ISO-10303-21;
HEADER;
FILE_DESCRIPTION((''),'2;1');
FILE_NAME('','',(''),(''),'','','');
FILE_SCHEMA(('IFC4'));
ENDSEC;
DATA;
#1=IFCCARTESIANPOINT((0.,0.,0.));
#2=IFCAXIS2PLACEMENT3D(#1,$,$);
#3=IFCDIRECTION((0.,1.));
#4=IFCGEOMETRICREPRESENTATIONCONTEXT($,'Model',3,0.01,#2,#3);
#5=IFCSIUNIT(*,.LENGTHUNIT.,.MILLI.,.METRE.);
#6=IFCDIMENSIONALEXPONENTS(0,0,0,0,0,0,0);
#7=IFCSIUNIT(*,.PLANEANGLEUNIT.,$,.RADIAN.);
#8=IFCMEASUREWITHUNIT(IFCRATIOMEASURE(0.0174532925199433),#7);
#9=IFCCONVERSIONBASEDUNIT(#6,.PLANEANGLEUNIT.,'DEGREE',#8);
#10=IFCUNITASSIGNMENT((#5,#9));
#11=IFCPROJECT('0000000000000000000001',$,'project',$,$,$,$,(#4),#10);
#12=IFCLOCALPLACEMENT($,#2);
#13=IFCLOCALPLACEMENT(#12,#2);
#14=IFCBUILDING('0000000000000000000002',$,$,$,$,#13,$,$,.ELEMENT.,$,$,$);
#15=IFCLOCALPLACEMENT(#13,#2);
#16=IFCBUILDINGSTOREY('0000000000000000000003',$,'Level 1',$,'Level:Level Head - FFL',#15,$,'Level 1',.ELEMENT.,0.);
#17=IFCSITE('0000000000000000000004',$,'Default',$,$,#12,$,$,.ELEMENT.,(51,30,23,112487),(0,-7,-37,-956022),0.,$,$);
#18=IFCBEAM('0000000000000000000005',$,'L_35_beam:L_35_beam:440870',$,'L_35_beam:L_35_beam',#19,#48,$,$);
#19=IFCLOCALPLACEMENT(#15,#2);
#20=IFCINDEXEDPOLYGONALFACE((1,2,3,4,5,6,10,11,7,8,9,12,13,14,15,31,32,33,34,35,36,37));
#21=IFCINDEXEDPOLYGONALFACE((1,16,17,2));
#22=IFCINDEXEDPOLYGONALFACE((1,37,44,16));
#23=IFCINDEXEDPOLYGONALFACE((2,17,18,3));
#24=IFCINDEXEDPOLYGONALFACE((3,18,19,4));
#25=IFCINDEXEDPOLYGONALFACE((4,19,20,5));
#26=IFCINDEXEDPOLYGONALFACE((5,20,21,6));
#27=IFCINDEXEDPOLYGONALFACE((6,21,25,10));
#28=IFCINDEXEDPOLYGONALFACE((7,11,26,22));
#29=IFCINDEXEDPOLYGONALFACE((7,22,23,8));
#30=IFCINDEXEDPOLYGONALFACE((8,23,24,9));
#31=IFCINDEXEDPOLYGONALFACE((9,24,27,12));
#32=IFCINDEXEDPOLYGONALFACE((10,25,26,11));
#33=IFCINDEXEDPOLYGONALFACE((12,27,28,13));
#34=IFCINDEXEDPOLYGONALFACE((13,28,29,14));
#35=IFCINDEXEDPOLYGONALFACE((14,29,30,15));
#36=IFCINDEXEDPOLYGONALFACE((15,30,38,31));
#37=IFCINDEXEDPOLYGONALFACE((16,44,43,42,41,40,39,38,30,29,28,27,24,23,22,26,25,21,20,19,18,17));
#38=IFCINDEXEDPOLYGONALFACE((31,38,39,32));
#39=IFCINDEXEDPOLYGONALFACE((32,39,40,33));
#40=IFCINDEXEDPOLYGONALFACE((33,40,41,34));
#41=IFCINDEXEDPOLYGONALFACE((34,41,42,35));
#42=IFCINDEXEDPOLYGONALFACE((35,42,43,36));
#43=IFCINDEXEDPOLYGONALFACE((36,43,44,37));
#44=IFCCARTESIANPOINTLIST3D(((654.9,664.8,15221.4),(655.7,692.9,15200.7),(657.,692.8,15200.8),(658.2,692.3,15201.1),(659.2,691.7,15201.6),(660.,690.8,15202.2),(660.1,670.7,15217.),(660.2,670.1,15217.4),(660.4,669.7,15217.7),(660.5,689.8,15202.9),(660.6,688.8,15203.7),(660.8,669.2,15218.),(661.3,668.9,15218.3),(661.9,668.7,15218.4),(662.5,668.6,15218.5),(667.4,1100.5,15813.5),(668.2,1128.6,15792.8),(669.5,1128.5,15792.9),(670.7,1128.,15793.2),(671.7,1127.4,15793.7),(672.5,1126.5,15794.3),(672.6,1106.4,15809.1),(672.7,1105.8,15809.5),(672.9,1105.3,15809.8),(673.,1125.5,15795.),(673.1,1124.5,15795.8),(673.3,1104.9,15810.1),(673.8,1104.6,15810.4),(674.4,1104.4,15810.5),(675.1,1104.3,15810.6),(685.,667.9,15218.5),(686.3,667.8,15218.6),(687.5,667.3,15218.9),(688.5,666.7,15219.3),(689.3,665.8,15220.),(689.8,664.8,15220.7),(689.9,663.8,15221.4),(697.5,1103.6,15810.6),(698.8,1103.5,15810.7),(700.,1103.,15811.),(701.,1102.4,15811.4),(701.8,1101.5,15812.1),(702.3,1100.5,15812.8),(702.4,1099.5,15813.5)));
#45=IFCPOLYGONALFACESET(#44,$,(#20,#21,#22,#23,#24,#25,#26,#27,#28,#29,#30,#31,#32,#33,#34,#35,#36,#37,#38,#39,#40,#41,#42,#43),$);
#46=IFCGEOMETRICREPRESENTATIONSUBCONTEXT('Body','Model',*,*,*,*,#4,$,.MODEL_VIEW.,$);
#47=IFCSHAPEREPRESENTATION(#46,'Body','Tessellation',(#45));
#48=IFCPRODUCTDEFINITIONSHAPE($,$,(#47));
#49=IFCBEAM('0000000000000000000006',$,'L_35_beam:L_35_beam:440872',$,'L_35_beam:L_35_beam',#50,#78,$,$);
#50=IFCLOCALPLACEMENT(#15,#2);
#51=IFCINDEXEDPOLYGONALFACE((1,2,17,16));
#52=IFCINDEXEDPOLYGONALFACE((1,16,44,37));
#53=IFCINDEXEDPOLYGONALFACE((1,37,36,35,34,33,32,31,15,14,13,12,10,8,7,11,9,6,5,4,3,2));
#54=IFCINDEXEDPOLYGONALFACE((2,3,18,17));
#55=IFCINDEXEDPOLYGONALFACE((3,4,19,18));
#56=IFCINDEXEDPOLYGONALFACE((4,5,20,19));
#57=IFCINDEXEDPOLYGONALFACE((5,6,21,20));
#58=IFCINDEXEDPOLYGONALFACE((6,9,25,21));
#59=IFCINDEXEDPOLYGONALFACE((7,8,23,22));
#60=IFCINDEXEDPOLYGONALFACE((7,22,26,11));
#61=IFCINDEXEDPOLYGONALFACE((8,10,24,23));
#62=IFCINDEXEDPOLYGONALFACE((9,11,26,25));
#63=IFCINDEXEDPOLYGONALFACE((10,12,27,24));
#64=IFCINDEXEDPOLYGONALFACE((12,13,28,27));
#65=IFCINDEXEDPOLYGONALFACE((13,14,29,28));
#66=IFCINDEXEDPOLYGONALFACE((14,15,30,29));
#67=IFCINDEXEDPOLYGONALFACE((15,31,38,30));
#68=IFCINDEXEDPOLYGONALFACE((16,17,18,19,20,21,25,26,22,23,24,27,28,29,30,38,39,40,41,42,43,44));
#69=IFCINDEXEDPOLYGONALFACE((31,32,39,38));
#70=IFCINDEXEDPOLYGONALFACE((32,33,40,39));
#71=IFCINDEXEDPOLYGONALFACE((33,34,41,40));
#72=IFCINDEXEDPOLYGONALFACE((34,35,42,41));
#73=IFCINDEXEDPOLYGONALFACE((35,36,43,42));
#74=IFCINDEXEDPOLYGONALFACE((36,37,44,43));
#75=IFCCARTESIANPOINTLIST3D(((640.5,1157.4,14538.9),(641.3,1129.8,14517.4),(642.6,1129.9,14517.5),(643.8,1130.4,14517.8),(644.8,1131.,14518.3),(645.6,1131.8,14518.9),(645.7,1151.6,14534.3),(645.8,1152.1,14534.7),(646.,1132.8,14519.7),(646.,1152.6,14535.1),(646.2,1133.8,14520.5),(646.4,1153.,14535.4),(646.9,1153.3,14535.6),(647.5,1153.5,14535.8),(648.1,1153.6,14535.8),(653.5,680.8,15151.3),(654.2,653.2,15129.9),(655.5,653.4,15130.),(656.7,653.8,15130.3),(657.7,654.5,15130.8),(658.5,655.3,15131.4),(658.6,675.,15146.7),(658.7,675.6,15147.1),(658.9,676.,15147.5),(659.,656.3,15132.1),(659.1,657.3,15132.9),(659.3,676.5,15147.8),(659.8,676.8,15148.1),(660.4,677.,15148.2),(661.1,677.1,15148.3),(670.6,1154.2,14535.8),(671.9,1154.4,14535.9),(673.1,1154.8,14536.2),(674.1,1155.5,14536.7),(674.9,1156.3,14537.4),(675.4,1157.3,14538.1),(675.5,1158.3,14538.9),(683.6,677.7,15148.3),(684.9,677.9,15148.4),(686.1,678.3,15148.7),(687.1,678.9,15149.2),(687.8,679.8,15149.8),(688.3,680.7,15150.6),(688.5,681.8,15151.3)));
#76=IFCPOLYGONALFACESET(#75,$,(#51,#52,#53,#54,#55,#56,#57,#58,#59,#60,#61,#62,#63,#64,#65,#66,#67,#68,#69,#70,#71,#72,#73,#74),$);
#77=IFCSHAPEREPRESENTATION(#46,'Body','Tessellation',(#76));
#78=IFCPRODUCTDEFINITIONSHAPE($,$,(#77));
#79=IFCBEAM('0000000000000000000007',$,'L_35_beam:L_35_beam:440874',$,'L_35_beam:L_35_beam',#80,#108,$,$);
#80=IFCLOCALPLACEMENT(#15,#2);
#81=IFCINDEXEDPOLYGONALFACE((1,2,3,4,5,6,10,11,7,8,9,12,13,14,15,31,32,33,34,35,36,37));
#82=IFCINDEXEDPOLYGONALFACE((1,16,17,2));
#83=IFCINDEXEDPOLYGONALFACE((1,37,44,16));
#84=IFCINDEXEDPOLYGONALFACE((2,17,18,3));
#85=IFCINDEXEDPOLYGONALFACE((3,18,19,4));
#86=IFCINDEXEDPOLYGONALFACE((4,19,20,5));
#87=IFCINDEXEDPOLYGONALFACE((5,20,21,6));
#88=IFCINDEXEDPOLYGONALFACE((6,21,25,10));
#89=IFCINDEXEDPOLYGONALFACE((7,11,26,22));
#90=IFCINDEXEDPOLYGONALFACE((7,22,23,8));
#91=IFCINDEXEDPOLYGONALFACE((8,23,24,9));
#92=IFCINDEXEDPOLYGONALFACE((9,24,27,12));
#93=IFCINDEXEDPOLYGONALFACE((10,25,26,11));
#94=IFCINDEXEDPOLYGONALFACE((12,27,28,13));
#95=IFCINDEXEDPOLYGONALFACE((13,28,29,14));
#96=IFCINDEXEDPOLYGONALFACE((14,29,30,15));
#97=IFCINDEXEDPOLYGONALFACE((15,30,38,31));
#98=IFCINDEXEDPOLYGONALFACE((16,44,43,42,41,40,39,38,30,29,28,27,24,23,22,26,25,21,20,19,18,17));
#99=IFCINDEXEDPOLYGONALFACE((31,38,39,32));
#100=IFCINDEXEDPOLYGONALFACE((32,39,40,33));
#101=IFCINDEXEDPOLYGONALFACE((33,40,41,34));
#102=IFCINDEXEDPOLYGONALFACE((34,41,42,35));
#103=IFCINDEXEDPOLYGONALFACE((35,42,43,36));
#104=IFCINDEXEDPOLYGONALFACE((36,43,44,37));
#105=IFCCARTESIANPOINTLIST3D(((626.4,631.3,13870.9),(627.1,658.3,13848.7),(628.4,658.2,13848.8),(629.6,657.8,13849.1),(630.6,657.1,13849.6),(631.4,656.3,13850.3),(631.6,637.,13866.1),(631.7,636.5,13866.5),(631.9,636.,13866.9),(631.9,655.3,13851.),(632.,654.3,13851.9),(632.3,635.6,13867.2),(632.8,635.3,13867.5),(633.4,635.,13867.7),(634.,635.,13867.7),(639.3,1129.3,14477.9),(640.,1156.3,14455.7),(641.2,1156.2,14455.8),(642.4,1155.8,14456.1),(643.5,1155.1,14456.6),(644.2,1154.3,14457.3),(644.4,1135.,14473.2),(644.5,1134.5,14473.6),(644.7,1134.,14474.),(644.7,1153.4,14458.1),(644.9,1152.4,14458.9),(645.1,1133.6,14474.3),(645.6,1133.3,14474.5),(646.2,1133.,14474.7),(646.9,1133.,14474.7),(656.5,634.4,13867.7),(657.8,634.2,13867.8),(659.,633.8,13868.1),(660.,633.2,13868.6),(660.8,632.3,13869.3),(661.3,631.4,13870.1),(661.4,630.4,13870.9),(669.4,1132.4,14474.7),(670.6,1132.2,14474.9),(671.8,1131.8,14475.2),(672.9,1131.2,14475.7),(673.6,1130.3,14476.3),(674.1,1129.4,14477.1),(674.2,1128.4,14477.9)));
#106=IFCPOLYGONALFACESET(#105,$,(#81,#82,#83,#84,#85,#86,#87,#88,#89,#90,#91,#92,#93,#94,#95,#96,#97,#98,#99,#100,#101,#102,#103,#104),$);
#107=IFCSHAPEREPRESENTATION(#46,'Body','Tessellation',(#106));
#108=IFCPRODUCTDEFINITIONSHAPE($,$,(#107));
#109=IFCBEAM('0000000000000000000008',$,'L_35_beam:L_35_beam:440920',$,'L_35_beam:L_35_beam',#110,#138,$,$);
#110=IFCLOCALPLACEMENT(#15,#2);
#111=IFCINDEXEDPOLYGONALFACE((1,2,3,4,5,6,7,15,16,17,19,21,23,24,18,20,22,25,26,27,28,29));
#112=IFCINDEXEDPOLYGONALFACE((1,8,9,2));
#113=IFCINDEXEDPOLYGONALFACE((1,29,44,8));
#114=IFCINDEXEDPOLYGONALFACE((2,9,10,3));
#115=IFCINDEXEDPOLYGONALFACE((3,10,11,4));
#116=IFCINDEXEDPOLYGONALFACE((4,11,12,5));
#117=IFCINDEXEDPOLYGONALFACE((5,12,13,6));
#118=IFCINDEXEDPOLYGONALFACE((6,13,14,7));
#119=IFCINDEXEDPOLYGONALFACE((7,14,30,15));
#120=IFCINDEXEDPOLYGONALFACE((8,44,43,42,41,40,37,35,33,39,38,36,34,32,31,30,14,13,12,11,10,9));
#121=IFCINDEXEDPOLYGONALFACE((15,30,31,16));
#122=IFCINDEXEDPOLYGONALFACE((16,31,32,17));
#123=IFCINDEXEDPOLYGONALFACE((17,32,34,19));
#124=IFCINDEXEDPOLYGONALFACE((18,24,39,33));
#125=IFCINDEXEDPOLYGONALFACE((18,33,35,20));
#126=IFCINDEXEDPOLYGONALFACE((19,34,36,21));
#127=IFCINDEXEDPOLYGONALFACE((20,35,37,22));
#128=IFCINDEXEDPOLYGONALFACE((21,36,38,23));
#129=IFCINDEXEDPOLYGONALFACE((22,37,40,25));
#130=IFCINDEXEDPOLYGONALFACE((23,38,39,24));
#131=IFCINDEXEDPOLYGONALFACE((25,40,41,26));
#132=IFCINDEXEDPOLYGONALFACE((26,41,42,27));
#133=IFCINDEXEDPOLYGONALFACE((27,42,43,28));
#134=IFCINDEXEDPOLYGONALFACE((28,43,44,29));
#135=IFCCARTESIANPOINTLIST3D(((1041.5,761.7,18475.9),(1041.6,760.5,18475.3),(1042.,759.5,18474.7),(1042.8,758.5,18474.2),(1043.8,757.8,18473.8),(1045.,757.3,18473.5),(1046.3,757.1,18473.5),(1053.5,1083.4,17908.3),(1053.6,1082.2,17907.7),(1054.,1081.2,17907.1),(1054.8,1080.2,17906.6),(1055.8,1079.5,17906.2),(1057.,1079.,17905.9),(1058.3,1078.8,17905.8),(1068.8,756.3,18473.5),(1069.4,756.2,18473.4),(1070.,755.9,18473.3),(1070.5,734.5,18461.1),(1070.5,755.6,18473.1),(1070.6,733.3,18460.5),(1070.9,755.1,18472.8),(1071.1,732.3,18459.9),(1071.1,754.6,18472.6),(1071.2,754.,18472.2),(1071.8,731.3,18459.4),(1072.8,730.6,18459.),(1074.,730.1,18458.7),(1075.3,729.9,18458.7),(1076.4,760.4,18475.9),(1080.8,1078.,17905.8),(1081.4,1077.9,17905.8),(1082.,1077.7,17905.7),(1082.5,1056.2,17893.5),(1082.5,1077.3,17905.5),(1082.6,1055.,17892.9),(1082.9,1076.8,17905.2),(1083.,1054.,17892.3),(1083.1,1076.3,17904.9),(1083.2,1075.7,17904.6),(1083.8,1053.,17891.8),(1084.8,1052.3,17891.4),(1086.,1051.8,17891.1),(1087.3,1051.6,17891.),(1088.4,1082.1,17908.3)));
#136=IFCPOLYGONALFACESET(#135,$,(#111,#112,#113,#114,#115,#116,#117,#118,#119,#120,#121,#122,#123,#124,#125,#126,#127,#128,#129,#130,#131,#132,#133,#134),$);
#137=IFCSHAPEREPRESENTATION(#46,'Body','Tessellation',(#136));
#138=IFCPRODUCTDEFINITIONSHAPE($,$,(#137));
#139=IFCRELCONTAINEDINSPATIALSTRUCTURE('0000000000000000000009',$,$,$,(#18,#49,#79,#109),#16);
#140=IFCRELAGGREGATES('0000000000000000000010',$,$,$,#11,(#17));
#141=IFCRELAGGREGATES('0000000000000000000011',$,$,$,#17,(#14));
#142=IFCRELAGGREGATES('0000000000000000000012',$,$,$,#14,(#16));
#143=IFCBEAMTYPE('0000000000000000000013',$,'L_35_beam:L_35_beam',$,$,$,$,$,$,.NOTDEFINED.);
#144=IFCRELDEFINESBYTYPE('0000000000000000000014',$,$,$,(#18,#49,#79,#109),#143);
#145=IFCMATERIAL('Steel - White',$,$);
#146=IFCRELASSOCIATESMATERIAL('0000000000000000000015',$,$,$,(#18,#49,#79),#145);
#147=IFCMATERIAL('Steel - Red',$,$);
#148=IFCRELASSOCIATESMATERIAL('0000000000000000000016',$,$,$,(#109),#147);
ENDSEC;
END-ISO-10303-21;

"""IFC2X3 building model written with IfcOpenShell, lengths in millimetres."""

from ifc_helpers import new_model, entity, si_unit, converted_unit, direction, frame, frame_2d, origin, place, context, subcontext, project, spatial, polyline, circle_curve, parameter, trimmed, segment, composite_curve, outline, extrude, material, type_object, element, save


model = new_model("IFC2X3")

# Units and contexts
model_context = context("Model", 3, precision=0.01, world=origin(), true_north=direction((0.0, 1.0)))
body_context = subcontext(model_context, "Body", "Model", "MODEL_VIEW")
ifc_project = project(units=[si_unit("LENGTHUNIT", "METRE", prefix="MILLI"), converted_unit("PLANEANGLEUNIT", "DEGREE", entity("IfcRatioMeasure", 0.0174532925199433), si_unit("PLANEANGLEUNIT", "RADIAN"), dimensions=[0, 0, 0, 0, 0, 0, 0])], contexts=[model_context])

# Site, building, storey
site_placement = place(None, origin())
site = spatial("IfcSite", under=ifc_project, at=site_placement, Name="Default", CompositionType="ELEMENT", RefLatitude=(51, 30, 23, 112487), RefLongitude=(0, -7, -37, -956022), RefElevation=0.0)
building_placement = place(site_placement, origin())
building = spatial("IfcBuilding", under=site, at=building_placement, CompositionType="ELEMENT")
storey_placement = place(building_placement, origin())
storey = spatial("IfcBuildingStorey", under=building, at=storey_placement, Name="Level 1", ObjectType="Level:Level Head - FFL", LongName="Level 1", CompositionType="ELEMENT", Elevation=0.0)

# Beams
ifc_material_1 = material(Name="Steel - Red")
ifc_material_2 = material(Name="Steel - White")
beam_type_1 = type_object("IfcBeamType", Name="L_35_beam:L_35_beam", PredefinedType="NOTDEFINED")
beam_1_placement = place(storey_placement, frame((646.4, 646.5, 15166.7), z_axis=(0.999855, -0.010085, -0.013705), x_axis=(0.017016, 0.592596, 0.80532)))
element("IfcBeam", 1, at=beam_1_placement, inside=storey, type_object=beam_type_1, material=ifc_material_2, Name="L_35_beam:L_35_beam:440870", ObjectType="L_35_beam:L_35_beam", context=body_context, shape_type="SweptSolid", body=[
    extrude(outline(composite_curve([segment(polyline([(-11.8, -11.8), (23.2, -11.8)]), True, "CONTINUOUS"), segment(trimmed(circle_curve(frame_2d((18.2, -11.8), x_axis=(1.0, 0.0)), 5.0), [parameter(0.0)], [parameter(90.0)], True, "PARAMETER"), True, "CONTINUOUS"), segment(polyline([(18.2, -6.8), (-4.3, -6.8)]), True, "CONTINUOUS"), segment(trimmed(circle_curve(frame_2d((-4.3, -4.3), x_axis=(0.0, -1.0)), 2.5), [parameter(270.0)], [parameter(0.0)], True, "PARAMETER"), False, "CONTINUOUS"), segment(polyline([(-6.8, -4.3), (-6.8, 18.2)]), True, "CONTINUOUS"), segment(trimmed(circle_curve(frame_2d((-11.8, 18.2), x_axis=(1.0, 0.0)), 5.0), [parameter(0.0)], [parameter(90.0)], True, "PARAMETER"), True, "CONTINUOUS"), segment(polyline([(-11.8, 23.2), (-11.8, -11.8)]), True, "CONTINUOUS")], self_intersect=False)), frame((55.0, 6.2, 19.6), z_axis=(1.0, 0.0, 0.0), x_axis=(0.0, 0.023118, 0.999733)), (0.0, 0.0, 1.0), 735.2),
])
beam_2_placement = place(storey_placement, frame((646.4, 646.5, 15166.7), z_axis=(0.999861, 0.010239, -0.013159), x_axis=(-0.016674, 0.614019, -0.789115)))
element("IfcBeam", 2, at=beam_2_placement, inside=storey, type_object=beam_type_1, material=ifc_material_2, Name="L_35_beam:L_35_beam:440872", ObjectType="L_35_beam:L_35_beam", context=body_context, shape_type="SweptSolid", body=[
    extrude(outline(composite_curve([segment(polyline([(-11.8, -11.8), (23.2, -11.8)]), True, "CONTINUOUS"), segment(trimmed(circle_curve(frame_2d((18.2, -11.8), x_axis=(1.0, 0.0)), 5.0), [parameter(0.0)], [parameter(90.0)], True, "PARAMETER"), True, "CONTINUOUS"), segment(polyline([(18.2, -6.8), (-4.3, -6.8)]), True, "CONTINUOUS"), segment(trimmed(circle_curve(frame_2d((-4.3, -4.3), x_axis=(0.0, -1.0)), 2.5), [parameter(270.0)], [parameter(0.0)], True, "PARAMETER"), False, "CONTINUOUS"), segment(polyline([(-6.8, -4.3), (-6.8, 18.2)]), True, "CONTINUOUS"), segment(trimmed(circle_curve(frame_2d((-11.8, 18.2), x_axis=(1.0, 0.0)), 5.0), [parameter(0.0)], [parameter(90.0)], True, "PARAMETER"), True, "CONTINUOUS"), segment(polyline([(-11.8, 23.2), (-11.8, -11.8)]), True, "CONTINUOUS")], self_intersect=False)), frame((33.1, 6.1, 19.7), z_axis=(1.0, 0.0, 0.0), x_axis=(0.0, 0.021423, 0.99977)), (0.0, 0.0, 1.0), 776.1),
])
beam_3_placement = place(storey_placement, frame((618.1, 618.2, 13827.0), z_axis=(0.999867, -0.01036, -0.012628), x_axis=(0.016334, 0.634177, 0.773016)))
element("IfcBeam", 3, at=beam_3_placement, inside=storey, type_object=beam_type_1, material=ifc_material_2, Name="L_35_beam:L_35_beam:440874", ObjectType="L_35_beam:L_35_beam", context=body_context, shape_type="SweptSolid", body=[
    extrude(outline(composite_curve([segment(polyline([(-11.8, -11.8), (23.2, -11.8)]), True, "CONTINUOUS"), segment(trimmed(circle_curve(frame_2d((18.2, -11.8), x_axis=(1.0, 0.0)), 5.0), [parameter(0.0)], [parameter(90.0)], True, "PARAMETER"), True, "CONTINUOUS"), segment(polyline([(18.2, -6.8), (-4.3, -6.8)]), True, "CONTINUOUS"), segment(trimmed(circle_curve(frame_2d((-4.3, -4.3), x_axis=(0.0, -1.0)), 2.5), [parameter(270.0)], [parameter(0.0)], True, "PARAMETER"), False, "CONTINUOUS"), segment(polyline([(-6.8, -4.3), (-6.8, 18.2)]), True, "CONTINUOUS"), segment(trimmed(circle_curve(frame_2d((-11.8, 18.2), x_axis=(1.0, 0.0)), 5.0), [parameter(0.0)], [parameter(90.0)], True, "PARAMETER"), True, "CONTINUOUS"), segment(polyline([(-11.8, 23.2), (-11.8, -11.8)]), True, "CONTINUOUS")], self_intersect=False)), frame((42.4, 6.1, 19.7), z_axis=(1.0, 0.0, 0.0), x_axis=(0.0, 0.019906, 0.999802)), (0.0, 0.0, 1.0), 785.3),
])
beam_4_placement = place(storey_placement, frame((1097.0, 1096.9, 17846.1), z_axis=(0.999831, -0.009062, 0.01599), x_axis=(-0.018379, -0.492997, 0.869837)))
element("IfcBeam", 4, at=beam_4_placement, inside=storey, type_object=beam_type_1, material=ifc_material_1, Name="L_35_beam:L_35_beam:440920", ObjectType="L_35_beam:L_35_beam", context=body_context, shape_type="SweptSolid", body=[
    extrude(outline(composite_curve([segment(polyline([(-23.2, -11.8), (11.8, -11.8)]), True, "CONTINUOUS"), segment(polyline([(11.8, -11.8), (11.8, 23.2)]), True, "CONTINUOUS"), segment(trimmed(circle_curve(frame_2d((11.8, 18.2), x_axis=(0.0, 1.0)), 5.0), [parameter(0.0)], [parameter(90.0)], True, "PARAMETER"), True, "CONTINUOUS"), segment(polyline([(6.8, 18.2), (6.8, -4.3)]), True, "CONTINUOUS"), segment(trimmed(circle_curve(frame_2d((4.3, -4.3), x_axis=(1.0, 0.0)), 2.5), [parameter(270.0)], [parameter(0.0)], True, "PARAMETER"), False, "CONTINUOUS"), segment(polyline([(4.3, -6.8), (-18.2, -6.8)]), True, "CONTINUOUS"), segment(trimmed(circle_curve(frame_2d((-18.2, -11.8), x_axis=(0.0, 1.0)), 5.0), [parameter(0.0)], [parameter(90.0)], True, "PARAMETER"), True, "CONTINUOUS")], self_intersect=False)), frame((61.6, -6.4, -19.6), z_axis=(1.0, 0.0, 0.0), x_axis=(0.0, -0.999475, 0.032411)), (0.0, 0.0, 1.0), 652.6),
])

save(model, "model.ifc")
